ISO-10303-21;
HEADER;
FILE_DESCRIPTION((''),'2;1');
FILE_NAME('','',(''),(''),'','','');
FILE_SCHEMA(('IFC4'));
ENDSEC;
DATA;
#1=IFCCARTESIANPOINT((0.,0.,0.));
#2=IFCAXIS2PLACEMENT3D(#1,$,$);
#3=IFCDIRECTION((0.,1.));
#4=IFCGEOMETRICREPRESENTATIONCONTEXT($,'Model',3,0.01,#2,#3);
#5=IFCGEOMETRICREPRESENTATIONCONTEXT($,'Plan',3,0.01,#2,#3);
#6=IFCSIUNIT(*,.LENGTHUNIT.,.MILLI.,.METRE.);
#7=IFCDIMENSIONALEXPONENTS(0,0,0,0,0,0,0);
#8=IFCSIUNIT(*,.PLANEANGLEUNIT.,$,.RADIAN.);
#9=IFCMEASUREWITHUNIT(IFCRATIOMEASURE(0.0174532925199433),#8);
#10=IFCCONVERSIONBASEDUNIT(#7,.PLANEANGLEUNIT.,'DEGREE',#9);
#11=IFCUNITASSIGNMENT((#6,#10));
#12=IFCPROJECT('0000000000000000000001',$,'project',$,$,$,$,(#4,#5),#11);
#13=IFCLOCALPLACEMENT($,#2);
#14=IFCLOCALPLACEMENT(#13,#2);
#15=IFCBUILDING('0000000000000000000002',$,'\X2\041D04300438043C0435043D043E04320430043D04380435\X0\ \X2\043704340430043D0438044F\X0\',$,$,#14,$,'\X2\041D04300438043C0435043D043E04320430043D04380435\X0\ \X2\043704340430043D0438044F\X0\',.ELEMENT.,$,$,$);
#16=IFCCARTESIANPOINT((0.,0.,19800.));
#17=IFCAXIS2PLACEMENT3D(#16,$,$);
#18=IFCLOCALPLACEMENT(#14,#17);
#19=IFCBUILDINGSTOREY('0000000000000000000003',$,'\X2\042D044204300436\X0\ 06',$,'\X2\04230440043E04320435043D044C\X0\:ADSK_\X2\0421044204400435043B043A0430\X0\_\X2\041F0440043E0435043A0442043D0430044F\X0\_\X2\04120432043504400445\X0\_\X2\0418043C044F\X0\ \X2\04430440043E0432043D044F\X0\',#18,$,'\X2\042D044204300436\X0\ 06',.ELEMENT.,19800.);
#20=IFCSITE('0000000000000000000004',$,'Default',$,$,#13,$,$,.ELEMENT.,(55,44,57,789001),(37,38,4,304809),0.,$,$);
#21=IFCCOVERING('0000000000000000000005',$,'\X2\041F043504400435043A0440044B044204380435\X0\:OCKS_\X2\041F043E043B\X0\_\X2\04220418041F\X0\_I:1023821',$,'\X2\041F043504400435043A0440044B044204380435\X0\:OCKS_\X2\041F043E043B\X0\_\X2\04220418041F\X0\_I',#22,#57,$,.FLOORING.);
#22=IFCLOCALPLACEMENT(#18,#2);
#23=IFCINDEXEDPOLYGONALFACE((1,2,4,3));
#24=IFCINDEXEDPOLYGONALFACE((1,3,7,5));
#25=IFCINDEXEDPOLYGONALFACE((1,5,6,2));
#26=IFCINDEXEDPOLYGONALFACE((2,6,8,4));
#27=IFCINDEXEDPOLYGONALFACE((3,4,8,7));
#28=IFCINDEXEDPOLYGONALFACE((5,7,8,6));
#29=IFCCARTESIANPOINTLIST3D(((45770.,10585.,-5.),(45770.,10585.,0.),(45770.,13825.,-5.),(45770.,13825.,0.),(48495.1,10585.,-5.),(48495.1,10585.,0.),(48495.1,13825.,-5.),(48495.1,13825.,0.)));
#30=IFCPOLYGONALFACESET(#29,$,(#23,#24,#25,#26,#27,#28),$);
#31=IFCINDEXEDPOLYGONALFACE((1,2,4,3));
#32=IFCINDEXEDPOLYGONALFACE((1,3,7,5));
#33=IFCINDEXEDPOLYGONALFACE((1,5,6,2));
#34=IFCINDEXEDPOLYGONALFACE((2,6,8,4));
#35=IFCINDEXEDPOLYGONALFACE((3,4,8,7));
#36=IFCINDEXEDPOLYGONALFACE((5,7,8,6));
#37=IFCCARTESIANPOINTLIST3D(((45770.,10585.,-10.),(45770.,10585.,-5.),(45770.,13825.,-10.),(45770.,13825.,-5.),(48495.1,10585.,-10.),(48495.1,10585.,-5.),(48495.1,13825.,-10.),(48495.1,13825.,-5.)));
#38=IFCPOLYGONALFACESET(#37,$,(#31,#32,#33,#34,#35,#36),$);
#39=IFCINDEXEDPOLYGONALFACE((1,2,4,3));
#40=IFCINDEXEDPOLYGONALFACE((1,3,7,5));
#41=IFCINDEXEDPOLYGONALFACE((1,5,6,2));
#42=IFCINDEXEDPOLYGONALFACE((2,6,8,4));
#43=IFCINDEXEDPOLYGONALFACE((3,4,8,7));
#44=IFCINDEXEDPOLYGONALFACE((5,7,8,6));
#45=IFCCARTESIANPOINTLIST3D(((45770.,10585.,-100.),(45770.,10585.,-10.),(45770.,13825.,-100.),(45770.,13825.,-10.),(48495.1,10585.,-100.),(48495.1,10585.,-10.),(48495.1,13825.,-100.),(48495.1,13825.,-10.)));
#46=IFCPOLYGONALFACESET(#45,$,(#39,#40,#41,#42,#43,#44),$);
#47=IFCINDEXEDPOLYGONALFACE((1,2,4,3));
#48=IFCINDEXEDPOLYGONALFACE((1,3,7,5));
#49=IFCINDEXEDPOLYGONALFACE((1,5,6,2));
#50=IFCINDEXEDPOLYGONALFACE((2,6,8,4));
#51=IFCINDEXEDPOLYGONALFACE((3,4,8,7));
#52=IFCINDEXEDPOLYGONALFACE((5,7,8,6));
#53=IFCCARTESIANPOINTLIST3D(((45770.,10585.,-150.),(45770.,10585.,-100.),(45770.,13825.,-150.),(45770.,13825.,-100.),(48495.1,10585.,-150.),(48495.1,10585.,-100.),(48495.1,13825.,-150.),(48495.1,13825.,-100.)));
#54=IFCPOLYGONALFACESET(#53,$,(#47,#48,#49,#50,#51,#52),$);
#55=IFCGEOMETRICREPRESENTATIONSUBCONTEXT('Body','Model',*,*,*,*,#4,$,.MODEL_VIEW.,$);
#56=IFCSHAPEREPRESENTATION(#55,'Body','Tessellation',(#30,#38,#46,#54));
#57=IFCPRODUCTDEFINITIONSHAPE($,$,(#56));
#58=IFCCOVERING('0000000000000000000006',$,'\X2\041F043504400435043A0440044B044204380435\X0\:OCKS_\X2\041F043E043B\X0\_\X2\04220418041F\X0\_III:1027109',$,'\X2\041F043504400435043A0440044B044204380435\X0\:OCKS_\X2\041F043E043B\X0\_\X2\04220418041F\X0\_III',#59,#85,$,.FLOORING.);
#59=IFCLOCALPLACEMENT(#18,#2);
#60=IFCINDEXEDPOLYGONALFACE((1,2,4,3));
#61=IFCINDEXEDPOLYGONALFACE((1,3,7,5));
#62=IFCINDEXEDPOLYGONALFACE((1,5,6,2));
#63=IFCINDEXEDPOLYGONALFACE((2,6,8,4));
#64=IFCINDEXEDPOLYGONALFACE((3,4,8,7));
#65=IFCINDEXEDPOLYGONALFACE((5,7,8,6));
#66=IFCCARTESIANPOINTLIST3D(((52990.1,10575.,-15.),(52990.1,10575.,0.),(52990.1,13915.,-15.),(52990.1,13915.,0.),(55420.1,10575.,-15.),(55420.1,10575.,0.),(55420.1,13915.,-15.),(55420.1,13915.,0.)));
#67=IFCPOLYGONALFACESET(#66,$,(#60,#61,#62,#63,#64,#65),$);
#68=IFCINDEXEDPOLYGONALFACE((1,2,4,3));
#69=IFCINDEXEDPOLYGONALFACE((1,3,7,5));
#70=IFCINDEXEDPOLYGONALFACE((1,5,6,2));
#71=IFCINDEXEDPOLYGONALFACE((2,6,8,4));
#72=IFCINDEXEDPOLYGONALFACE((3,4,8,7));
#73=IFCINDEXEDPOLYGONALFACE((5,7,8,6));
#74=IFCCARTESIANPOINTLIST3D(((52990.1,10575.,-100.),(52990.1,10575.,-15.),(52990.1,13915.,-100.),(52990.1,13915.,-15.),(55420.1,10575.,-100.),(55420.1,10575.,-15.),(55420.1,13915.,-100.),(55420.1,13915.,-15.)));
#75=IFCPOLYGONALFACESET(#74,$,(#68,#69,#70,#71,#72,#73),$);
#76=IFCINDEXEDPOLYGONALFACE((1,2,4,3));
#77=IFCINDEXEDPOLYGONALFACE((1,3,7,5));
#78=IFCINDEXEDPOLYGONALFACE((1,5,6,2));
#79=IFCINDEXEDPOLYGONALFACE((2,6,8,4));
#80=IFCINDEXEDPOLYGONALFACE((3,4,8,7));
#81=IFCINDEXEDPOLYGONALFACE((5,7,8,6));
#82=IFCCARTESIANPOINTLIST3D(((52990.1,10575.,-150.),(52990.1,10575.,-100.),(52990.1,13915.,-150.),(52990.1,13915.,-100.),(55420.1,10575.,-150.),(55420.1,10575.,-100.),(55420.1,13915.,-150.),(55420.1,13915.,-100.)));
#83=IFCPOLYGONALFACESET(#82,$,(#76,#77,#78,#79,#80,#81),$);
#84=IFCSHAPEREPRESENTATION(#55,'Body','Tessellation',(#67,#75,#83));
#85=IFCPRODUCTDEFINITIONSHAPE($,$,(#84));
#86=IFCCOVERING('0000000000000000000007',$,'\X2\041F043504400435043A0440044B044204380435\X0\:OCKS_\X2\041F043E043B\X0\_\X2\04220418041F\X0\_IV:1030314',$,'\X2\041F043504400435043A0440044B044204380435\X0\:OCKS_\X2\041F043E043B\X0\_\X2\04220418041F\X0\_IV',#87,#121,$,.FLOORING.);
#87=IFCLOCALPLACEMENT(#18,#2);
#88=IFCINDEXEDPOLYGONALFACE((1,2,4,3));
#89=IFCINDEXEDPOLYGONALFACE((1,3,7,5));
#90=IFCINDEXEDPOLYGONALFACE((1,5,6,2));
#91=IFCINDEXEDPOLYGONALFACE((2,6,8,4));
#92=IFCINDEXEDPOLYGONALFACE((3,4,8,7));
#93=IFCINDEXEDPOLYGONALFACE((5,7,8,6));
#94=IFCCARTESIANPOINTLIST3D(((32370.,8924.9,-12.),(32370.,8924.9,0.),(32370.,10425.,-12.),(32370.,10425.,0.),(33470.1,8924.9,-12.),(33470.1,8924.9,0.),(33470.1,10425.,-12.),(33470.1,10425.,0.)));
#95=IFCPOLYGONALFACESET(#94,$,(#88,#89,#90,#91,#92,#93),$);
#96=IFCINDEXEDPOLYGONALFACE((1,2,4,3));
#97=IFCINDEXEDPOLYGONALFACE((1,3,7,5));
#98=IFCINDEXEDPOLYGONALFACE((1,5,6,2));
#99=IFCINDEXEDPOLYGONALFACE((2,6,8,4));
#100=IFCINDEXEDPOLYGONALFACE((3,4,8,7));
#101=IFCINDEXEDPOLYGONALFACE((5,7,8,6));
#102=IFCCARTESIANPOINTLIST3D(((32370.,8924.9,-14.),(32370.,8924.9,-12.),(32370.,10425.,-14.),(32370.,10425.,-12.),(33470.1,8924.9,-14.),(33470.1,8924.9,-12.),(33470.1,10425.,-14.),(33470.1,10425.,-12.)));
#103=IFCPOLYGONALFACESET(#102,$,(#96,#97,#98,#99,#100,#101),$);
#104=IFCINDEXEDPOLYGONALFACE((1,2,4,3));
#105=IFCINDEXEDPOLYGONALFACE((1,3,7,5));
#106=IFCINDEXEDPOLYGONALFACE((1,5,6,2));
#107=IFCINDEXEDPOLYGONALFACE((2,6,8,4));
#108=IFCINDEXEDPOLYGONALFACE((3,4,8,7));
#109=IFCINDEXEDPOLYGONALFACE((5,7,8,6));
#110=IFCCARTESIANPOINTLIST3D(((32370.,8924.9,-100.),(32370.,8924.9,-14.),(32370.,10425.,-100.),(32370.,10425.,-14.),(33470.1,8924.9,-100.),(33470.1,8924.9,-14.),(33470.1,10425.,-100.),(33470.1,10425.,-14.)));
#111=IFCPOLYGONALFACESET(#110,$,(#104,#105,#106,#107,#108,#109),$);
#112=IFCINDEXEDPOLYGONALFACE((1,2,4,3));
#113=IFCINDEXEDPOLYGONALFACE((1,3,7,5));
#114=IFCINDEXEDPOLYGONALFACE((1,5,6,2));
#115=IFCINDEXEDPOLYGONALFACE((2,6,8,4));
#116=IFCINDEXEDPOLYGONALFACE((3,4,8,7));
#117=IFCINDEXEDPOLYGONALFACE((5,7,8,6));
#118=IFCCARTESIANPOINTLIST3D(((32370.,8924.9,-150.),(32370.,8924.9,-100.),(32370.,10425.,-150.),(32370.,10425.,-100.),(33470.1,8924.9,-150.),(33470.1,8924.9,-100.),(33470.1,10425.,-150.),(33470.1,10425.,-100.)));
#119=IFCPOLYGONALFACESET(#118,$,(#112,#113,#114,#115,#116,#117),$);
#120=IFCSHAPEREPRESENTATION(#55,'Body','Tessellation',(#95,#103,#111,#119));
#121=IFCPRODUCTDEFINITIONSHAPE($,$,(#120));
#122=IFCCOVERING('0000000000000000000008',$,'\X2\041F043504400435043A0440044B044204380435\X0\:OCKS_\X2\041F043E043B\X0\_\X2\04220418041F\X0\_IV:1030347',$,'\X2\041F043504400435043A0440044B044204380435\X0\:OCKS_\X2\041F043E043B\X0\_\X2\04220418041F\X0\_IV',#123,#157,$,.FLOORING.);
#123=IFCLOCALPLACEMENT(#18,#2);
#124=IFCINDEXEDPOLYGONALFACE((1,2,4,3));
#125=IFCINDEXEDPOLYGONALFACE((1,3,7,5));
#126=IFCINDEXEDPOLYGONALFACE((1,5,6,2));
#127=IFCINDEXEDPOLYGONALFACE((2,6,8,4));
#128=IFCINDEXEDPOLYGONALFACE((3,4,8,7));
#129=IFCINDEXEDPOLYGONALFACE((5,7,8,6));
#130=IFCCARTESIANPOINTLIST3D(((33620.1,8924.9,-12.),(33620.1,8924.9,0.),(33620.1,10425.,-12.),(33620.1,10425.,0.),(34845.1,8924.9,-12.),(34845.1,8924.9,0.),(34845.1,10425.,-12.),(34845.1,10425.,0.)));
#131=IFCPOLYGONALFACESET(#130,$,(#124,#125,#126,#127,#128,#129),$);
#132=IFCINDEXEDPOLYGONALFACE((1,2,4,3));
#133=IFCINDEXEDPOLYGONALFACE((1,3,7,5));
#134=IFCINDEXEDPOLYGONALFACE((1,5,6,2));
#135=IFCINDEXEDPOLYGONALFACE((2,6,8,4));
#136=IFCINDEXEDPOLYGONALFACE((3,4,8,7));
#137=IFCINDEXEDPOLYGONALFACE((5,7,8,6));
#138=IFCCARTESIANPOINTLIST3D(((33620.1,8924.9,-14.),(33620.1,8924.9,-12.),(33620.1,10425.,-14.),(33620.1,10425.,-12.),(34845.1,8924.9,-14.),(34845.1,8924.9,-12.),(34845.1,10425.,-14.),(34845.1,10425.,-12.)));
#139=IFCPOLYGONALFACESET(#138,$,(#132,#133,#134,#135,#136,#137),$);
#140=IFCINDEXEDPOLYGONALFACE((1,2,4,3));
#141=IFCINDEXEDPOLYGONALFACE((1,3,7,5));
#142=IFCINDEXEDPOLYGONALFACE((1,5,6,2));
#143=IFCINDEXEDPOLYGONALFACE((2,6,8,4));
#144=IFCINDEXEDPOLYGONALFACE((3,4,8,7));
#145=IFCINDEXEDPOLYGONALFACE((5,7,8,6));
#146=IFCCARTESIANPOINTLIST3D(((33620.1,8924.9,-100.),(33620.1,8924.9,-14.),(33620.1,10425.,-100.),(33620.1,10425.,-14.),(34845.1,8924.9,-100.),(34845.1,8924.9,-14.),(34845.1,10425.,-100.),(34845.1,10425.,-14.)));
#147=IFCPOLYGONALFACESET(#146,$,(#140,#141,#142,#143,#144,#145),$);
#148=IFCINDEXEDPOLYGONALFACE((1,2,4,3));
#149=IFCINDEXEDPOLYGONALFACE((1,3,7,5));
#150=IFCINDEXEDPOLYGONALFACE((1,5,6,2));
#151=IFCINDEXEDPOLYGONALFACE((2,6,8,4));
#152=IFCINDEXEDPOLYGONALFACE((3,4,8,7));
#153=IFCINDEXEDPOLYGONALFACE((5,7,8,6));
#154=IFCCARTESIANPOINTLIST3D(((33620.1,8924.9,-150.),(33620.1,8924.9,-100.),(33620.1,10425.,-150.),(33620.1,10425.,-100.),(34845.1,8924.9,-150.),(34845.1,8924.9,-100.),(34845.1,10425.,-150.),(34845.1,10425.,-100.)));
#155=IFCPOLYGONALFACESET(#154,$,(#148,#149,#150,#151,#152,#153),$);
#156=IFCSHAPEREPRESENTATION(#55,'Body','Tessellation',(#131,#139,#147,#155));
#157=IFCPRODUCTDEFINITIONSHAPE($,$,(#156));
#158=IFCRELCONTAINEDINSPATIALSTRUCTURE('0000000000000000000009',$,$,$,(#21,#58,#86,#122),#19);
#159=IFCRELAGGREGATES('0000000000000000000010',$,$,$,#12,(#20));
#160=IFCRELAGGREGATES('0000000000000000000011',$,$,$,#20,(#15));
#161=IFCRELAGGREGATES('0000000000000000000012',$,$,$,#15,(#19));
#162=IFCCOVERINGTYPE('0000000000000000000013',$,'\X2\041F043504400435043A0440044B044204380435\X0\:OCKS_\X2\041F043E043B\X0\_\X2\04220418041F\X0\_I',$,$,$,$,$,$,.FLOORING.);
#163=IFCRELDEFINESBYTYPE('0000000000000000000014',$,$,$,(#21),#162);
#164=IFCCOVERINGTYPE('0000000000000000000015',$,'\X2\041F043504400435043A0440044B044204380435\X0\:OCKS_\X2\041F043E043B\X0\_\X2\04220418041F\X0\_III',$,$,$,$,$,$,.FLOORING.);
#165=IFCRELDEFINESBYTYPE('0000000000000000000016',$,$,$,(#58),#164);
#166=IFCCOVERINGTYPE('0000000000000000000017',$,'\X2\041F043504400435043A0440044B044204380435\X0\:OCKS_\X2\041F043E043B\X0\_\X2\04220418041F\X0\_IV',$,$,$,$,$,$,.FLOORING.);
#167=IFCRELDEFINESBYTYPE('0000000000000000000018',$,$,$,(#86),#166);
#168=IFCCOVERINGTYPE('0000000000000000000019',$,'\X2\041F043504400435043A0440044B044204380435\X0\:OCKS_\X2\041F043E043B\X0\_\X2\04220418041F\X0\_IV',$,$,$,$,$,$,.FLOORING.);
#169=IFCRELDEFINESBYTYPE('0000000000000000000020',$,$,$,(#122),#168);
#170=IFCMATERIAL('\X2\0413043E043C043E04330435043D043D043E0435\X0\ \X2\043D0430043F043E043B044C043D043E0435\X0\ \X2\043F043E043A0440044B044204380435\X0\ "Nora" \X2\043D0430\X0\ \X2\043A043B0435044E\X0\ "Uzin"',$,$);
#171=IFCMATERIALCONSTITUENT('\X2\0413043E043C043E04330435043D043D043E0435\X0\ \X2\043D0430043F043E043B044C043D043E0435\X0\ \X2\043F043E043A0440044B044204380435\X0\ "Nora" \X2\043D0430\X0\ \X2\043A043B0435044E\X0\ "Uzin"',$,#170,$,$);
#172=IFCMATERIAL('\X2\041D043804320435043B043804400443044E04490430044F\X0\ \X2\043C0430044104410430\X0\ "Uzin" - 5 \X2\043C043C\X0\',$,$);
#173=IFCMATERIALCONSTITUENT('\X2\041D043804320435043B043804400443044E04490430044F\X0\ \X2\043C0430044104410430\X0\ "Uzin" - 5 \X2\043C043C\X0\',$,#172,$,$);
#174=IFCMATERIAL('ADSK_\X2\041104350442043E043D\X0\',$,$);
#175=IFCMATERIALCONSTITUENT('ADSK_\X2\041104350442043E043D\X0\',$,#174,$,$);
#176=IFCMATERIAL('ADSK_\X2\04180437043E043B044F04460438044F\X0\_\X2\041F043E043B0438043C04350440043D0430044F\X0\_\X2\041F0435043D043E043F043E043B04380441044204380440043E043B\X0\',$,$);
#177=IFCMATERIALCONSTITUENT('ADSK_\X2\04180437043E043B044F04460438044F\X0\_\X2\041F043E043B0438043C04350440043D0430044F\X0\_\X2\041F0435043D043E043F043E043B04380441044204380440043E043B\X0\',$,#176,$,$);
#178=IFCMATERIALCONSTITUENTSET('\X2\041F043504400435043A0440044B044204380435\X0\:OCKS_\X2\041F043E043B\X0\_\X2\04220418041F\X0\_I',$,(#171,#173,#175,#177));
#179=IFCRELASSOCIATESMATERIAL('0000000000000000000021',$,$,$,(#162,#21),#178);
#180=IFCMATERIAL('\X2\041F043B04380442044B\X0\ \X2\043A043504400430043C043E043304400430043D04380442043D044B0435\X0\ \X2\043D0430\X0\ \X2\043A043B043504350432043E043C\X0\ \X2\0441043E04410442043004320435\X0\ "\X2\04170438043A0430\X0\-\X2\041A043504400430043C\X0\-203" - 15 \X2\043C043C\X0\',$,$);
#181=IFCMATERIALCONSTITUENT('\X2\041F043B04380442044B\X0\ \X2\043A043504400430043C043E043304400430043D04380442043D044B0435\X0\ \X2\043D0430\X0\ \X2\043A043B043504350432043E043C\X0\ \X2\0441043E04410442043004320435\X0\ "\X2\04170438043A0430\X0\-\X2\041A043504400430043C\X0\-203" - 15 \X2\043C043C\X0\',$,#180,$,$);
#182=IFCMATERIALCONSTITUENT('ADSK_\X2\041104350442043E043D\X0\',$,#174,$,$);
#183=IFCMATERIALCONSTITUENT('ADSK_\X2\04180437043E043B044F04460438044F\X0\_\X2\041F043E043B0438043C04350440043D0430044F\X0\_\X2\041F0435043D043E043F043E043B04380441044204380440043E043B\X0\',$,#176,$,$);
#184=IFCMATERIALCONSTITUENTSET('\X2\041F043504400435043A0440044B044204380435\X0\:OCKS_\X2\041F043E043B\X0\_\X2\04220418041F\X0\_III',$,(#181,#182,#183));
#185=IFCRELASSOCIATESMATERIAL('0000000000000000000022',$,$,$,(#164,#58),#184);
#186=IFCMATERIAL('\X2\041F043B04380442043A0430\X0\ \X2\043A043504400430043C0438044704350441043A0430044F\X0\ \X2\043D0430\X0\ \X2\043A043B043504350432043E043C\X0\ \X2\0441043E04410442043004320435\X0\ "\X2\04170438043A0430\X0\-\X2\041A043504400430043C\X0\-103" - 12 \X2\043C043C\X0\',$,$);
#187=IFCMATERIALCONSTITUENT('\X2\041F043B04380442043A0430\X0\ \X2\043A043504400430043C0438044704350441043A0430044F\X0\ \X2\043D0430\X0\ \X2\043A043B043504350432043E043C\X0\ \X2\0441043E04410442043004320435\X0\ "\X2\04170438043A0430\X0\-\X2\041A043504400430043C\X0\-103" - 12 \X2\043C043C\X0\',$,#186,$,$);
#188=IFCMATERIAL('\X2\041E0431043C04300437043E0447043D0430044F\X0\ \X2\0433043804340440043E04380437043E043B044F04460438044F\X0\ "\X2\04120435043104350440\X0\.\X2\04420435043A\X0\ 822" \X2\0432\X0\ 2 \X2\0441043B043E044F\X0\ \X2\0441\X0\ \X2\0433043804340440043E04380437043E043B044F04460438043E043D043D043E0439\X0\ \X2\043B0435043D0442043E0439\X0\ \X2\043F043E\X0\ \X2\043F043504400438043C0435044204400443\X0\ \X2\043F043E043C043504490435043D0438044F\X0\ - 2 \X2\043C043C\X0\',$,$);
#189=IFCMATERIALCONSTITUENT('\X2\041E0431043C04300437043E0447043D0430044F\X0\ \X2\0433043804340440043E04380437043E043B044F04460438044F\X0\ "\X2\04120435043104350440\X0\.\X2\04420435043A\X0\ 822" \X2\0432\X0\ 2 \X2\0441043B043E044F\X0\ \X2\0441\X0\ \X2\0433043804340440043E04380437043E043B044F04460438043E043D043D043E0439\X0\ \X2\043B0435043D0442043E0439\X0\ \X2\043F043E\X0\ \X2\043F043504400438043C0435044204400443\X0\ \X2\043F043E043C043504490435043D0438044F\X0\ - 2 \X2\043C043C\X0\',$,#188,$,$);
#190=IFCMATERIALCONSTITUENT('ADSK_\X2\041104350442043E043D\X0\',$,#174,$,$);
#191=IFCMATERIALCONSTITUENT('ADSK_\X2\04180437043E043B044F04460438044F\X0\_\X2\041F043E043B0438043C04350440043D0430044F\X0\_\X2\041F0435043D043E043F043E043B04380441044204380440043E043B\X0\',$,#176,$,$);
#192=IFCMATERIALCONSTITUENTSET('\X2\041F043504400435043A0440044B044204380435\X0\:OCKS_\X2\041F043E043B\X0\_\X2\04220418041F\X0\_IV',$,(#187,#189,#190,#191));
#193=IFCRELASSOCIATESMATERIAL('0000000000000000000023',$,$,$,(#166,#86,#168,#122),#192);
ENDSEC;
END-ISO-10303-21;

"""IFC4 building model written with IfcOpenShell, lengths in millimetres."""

from ifc_helpers import new_model, entity, si_unit, converted_unit, direction, frame, origin, place, context, subcontext, project, spatial, indexed_curve, outline, extrude, material, constituent, constituent_set, type_object, element, save


model = new_model("IFC4")

# Units and contexts
model_context = context("Model", 3, precision=0.01, world=origin(), true_north=direction((0.0, 1.0)))
plan_context = context("Plan", 3, precision=0.01, world=origin(), true_north=direction((0.0, 1.0)))
body_context = subcontext(model_context, "Body", "Model", "MODEL_VIEW")
ifc_project = project(units=[si_unit("LENGTHUNIT", "METRE", prefix="MILLI"), converted_unit("PLANEANGLEUNIT", "DEGREE", entity("IfcRatioMeasure", 0.0174532925199433), si_unit("PLANEANGLEUNIT", "RADIAN"), dimensions=[0, 0, 0, 0, 0, 0, 0])], contexts=[model_context, plan_context])

# Site, building, storey
site_placement = place(None, frame((0.0, 0.0, 0.0)))
site = spatial("IfcSite", under=ifc_project, at=site_placement, Name="Default", CompositionType="ELEMENT", RefLatitude=(55, 44, 57, 789001), RefLongitude=(37, 38, 4, 304809), RefElevation=0.0)
building_placement = place(site_placement, origin())
building = spatial("IfcBuilding", under=site, at=building_placement, Name="Наименование здания", LongName="Наименование здания", CompositionType="ELEMENT")
storey_placement = place(building_placement, frame((0.0, 0.0, 19800.0)))
storey = spatial("IfcBuildingStorey", under=building, at=storey_placement, Name="Этаж 06", ObjectType="Уровень:ADSK_Стрелка_Проектная_Вверх_Имя уровня", LongName="Этаж 06", CompositionType="ELEMENT", Elevation=19800.0)

# Coverings
ifc_material_1 = material(Name="Плиты керамогранитные на клеевом составе \"Зика-Керам-203\" - 15 мм")
ifc_material_2 = material(Name="Обмазочная гидроизоляция \"Вебер.тек 822\" в 2 слоя с гидроизоляционной лентой по периметру помещения - 2 мм")
ifc_material_3 = material(Name="ADSK_Бетон")
ifc_material_4 = material(Name="ADSK_Изоляция_Полимерная_Пенополистирол")
ifc_constituent_1 = constituent(ifc_material_1, Name="Плиты керамогранитные на клеевом составе \"Зика-Керам-203\" - 15 мм")
ifc_constituent_2 = constituent(ifc_material_3, Name="ADSK_Бетон")
ifc_constituent_3 = constituent(ifc_material_4, Name="ADSK_Изоляция_Полимерная_Пенополистирол")
ifc_constituent_set_1 = constituent_set(constituents=[ifc_constituent_1, ifc_constituent_2, ifc_constituent_3], Name="Перекрытие:OCKS_Пол_ТИП_III")
ifc_material_5 = material(Name="Гомогенное напольное покрытие \"Nora\" на клею \"Uzin\"")
ifc_constituent_4 = constituent(ifc_material_5, Name="Гомогенное напольное покрытие \"Nora\" на клею \"Uzin\"")
ifc_material_6 = material(Name="Нивелирующая масса \"Uzin\" - 5 мм")
ifc_constituent_5 = constituent(ifc_material_6, Name="Нивелирующая масса \"Uzin\" - 5 мм")
ifc_constituent_6 = constituent(ifc_material_3, Name="ADSK_Бетон")
ifc_constituent_7 = constituent(ifc_material_4, Name="ADSK_Изоляция_Полимерная_Пенополистирол")
ifc_constituent_set_2 = constituent_set(constituents=[ifc_constituent_4, ifc_constituent_5, ifc_constituent_6, ifc_constituent_7], Name="Перекрытие:OCKS_Пол_ТИП_I")
ifc_material_7 = material(Name="Плитка керамическая на клеевом составе \"Зика-Керам-103\" - 12 мм")
ifc_constituent_8 = constituent(ifc_material_7, Name="Плитка керамическая на клеевом составе \"Зика-Керам-103\" - 12 мм")
ifc_constituent_9 = constituent(ifc_material_2, Name="Обмазочная гидроизоляция \"Вебер.тек 822\" в 2 слоя с гидроизоляционной лентой по периметру помещения - 2 мм")
ifc_constituent_10 = constituent(ifc_material_3, Name="ADSK_Бетон")
ifc_constituent_11 = constituent(ifc_material_4, Name="ADSK_Изоляция_Полимерная_Пенополистирол")
ifc_constituent_set_3 = constituent_set(constituents=[ifc_constituent_8, ifc_constituent_9, ifc_constituent_10, ifc_constituent_11], Name="Перекрытие:OCKS_Пол_ТИП_IV")
covering_type_1 = type_object("IfcCoveringType", Name="Перекрытие:OCKS_Пол_ТИП_I", PredefinedType="FLOORING", material=ifc_constituent_set_2)
covering_1_placement = place(storey_placement, origin())
element("IfcCovering", 1, at=covering_1_placement, inside=storey, type_object=covering_type_1, material=ifc_constituent_set_2, Name="Перекрытие:OCKS_Пол_ТИП_I:1023821", ObjectType="Перекрытие:OCKS_Пол_ТИП_I", PredefinedType="FLOORING", context=body_context, shape_type="SweptSolid", body=[
    extrude(outline(indexed_curve([(-1362.6, -1620.0), (1362.6, -1620.0), (1362.6, 1620.0), (-1362.6, 1620.0), (-1362.6, -1620.0)], self_intersect=False)), frame((47132.6, 12205.0, -5.0), z_axis=(0.0, 0.0, 1.0), x_axis=(-1.0, 0.0, 0.0)), (0.0, 0.0, 1.0), 5.0),
    extrude(outline(indexed_curve([(-1362.6, -1620.0), (1362.6, -1620.0), (1362.6, 1620.0), (-1362.6, 1620.0), (-1362.6, -1620.0)], self_intersect=False)), frame((47132.6, 12205.0, -10.0), z_axis=(0.0, 0.0, 1.0), x_axis=(-1.0, 0.0, 0.0)), (0.0, 0.0, 1.0), 5.0),
    extrude(outline(indexed_curve([(-1362.6, -1620.0), (1362.6, -1620.0), (1362.6, 1620.0), (-1362.6, 1620.0), (-1362.6, -1620.0)], self_intersect=False)), frame((47132.6, 12205.0, -100.0), z_axis=(0.0, 0.0, 1.0), x_axis=(-1.0, 0.0, 0.0)), (0.0, 0.0, 1.0), 90.0),
    extrude(outline(indexed_curve([(-1362.6, -1620.0), (1362.6, -1620.0), (1362.6, 1620.0), (-1362.6, 1620.0), (-1362.6, -1620.0)], self_intersect=False)), frame((47132.6, 12205.0, -150.0), z_axis=(0.0, 0.0, 1.0), x_axis=(-1.0, 0.0, 0.0)), (0.0, 0.0, 1.0), 50.0),
])
covering_type_2 = type_object("IfcCoveringType", Name="Перекрытие:OCKS_Пол_ТИП_III", PredefinedType="FLOORING", material=ifc_constituent_set_1)
covering_2_placement = place(storey_placement, origin())
element("IfcCovering", 2, at=covering_2_placement, inside=storey, type_object=covering_type_2, material=ifc_constituent_set_1, Name="Перекрытие:OCKS_Пол_ТИП_III:1027109", ObjectType="Перекрытие:OCKS_Пол_ТИП_III", PredefinedType="FLOORING", context=body_context, shape_type="SweptSolid", body=[
    extrude(outline(indexed_curve([(-1670.0, -1215.0), (1670.0, -1215.0), (1670.0, 1215.0), (-1670.0, 1215.0), (-1670.0, -1215.0)], self_intersect=False)), frame((54205.1, 12245.0, -15.0), z_axis=(0.0, 0.0, 1.0), x_axis=(0.0, -1.0, 0.0)), (0.0, 0.0, 1.0), 15.0),
    extrude(outline(indexed_curve([(-1670.0, -1215.0), (1670.0, -1215.0), (1670.0, 1215.0), (-1670.0, 1215.0), (-1670.0, -1215.0)], self_intersect=False)), frame((54205.1, 12245.0, -100.0), z_axis=(0.0, 0.0, 1.0), x_axis=(0.0, -1.0, 0.0)), (0.0, 0.0, 1.0), 85.0),
    extrude(outline(indexed_curve([(-1670.0, -1215.0), (1670.0, -1215.0), (1670.0, 1215.0), (-1670.0, 1215.0), (-1670.0, -1215.0)], self_intersect=False)), frame((54205.1, 12245.0, -150.0), z_axis=(0.0, 0.0, 1.0), x_axis=(0.0, -1.0, 0.0)), (0.0, 0.0, 1.0), 50.0),
])
covering_type_3 = type_object("IfcCoveringType", Name="Перекрытие:OCKS_Пол_ТИП_IV", PredefinedType="FLOORING", material=ifc_constituent_set_3)
covering_3_placement = place(storey_placement, origin())
element("IfcCovering", 3, at=covering_3_placement, inside=storey, type_object=covering_type_3, material=ifc_constituent_set_3, Name="Перекрытие:OCKS_Пол_ТИП_IV:1030314", ObjectType="Перекрытие:OCKS_Пол_ТИП_IV", PredefinedType="FLOORING", context=body_context, shape_type="SweptSolid", body=[
    extrude(outline(indexed_curve([(-550.1, -750.0), (550.1, -750.0), (550.1, 750.0), (-550.1, 750.0), (-550.1, -750.0)], self_intersect=False)), frame((32920.1, 9675.0, -12.0), z_axis=(0.0, 0.0, 1.0), x_axis=(-1.0, 0.0, 0.0)), (0.0, 0.0, 1.0), 12.0),
    extrude(outline(indexed_curve([(-550.1, -750.0), (550.1, -750.0), (550.1, 750.0), (-550.1, 750.0), (-550.1, -750.0)], self_intersect=False)), frame((32920.1, 9675.0, -14.0), z_axis=(0.0, 0.0, 1.0), x_axis=(-1.0, 0.0, 0.0)), (0.0, 0.0, 1.0), 2.0),
    extrude(outline(indexed_curve([(-550.1, -750.0), (550.1, -750.0), (550.1, 750.0), (-550.1, 750.0), (-550.1, -750.0)], self_intersect=False)), frame((32920.1, 9675.0, -100.0), z_axis=(0.0, 0.0, 1.0), x_axis=(-1.0, 0.0, 0.0)), (0.0, 0.0, 1.0), 86.0),
    extrude(outline(indexed_curve([(-550.1, -750.0), (550.1, -750.0), (550.1, 750.0), (-550.1, 750.0), (-550.1, -750.0)], self_intersect=False)), frame((32920.1, 9675.0, -150.0), z_axis=(0.0, 0.0, 1.0), x_axis=(-1.0, 0.0, 0.0)), (0.0, 0.0, 1.0), 50.0),
])
covering_type_4 = type_object("IfcCoveringType", Name="Перекрытие:OCKS_Пол_ТИП_IV", PredefinedType="FLOORING", material=ifc_constituent_set_3)
covering_4_placement = place(storey_placement, origin())
element("IfcCovering", 4, at=covering_4_placement, inside=storey, type_object=covering_type_4, material=ifc_constituent_set_3, Name="Перекрытие:OCKS_Пол_ТИП_IV:1030347", ObjectType="Перекрытие:OCKS_Пол_ТИП_IV", PredefinedType="FLOORING", context=body_context, shape_type="SweptSolid", body=[
    extrude(outline(indexed_curve([(-612.5, -750.0), (612.5, -750.0), (612.5, 750.0), (-612.5, 750.0), (-612.5, -750.0)], self_intersect=False)), frame((34232.6, 9675.0, -12.0), z_axis=(0.0, 0.0, 1.0), x_axis=(-1.0, 0.0, 0.0)), (0.0, 0.0, 1.0), 12.0),
    extrude(outline(indexed_curve([(-612.5, -750.0), (612.5, -750.0), (612.5, 750.0), (-612.5, 750.0), (-612.5, -750.0)], self_intersect=False)), frame((34232.6, 9675.0, -14.0), z_axis=(0.0, 0.0, 1.0), x_axis=(-1.0, 0.0, 0.0)), (0.0, 0.0, 1.0), 2.0),
    extrude(outline(indexed_curve([(-612.5, -750.0), (612.5, -750.0), (612.5, 750.0), (-612.5, 750.0), (-612.5, -750.0)], self_intersect=False)), frame((34232.6, 9675.0, -100.0), z_axis=(0.0, 0.0, 1.0), x_axis=(-1.0, 0.0, 0.0)), (0.0, 0.0, 1.0), 86.0),
    extrude(outline(indexed_curve([(-612.5, -750.0), (612.5, -750.0), (612.5, 750.0), (-612.5, 750.0), (-612.5, -750.0)], self_intersect=False)), frame((34232.6, 9675.0, -150.0), z_axis=(0.0, 0.0, 1.0), x_axis=(-1.0, 0.0, 0.0)), (0.0, 0.0, 1.0), 50.0),
])

save(model, "model.ifc")
